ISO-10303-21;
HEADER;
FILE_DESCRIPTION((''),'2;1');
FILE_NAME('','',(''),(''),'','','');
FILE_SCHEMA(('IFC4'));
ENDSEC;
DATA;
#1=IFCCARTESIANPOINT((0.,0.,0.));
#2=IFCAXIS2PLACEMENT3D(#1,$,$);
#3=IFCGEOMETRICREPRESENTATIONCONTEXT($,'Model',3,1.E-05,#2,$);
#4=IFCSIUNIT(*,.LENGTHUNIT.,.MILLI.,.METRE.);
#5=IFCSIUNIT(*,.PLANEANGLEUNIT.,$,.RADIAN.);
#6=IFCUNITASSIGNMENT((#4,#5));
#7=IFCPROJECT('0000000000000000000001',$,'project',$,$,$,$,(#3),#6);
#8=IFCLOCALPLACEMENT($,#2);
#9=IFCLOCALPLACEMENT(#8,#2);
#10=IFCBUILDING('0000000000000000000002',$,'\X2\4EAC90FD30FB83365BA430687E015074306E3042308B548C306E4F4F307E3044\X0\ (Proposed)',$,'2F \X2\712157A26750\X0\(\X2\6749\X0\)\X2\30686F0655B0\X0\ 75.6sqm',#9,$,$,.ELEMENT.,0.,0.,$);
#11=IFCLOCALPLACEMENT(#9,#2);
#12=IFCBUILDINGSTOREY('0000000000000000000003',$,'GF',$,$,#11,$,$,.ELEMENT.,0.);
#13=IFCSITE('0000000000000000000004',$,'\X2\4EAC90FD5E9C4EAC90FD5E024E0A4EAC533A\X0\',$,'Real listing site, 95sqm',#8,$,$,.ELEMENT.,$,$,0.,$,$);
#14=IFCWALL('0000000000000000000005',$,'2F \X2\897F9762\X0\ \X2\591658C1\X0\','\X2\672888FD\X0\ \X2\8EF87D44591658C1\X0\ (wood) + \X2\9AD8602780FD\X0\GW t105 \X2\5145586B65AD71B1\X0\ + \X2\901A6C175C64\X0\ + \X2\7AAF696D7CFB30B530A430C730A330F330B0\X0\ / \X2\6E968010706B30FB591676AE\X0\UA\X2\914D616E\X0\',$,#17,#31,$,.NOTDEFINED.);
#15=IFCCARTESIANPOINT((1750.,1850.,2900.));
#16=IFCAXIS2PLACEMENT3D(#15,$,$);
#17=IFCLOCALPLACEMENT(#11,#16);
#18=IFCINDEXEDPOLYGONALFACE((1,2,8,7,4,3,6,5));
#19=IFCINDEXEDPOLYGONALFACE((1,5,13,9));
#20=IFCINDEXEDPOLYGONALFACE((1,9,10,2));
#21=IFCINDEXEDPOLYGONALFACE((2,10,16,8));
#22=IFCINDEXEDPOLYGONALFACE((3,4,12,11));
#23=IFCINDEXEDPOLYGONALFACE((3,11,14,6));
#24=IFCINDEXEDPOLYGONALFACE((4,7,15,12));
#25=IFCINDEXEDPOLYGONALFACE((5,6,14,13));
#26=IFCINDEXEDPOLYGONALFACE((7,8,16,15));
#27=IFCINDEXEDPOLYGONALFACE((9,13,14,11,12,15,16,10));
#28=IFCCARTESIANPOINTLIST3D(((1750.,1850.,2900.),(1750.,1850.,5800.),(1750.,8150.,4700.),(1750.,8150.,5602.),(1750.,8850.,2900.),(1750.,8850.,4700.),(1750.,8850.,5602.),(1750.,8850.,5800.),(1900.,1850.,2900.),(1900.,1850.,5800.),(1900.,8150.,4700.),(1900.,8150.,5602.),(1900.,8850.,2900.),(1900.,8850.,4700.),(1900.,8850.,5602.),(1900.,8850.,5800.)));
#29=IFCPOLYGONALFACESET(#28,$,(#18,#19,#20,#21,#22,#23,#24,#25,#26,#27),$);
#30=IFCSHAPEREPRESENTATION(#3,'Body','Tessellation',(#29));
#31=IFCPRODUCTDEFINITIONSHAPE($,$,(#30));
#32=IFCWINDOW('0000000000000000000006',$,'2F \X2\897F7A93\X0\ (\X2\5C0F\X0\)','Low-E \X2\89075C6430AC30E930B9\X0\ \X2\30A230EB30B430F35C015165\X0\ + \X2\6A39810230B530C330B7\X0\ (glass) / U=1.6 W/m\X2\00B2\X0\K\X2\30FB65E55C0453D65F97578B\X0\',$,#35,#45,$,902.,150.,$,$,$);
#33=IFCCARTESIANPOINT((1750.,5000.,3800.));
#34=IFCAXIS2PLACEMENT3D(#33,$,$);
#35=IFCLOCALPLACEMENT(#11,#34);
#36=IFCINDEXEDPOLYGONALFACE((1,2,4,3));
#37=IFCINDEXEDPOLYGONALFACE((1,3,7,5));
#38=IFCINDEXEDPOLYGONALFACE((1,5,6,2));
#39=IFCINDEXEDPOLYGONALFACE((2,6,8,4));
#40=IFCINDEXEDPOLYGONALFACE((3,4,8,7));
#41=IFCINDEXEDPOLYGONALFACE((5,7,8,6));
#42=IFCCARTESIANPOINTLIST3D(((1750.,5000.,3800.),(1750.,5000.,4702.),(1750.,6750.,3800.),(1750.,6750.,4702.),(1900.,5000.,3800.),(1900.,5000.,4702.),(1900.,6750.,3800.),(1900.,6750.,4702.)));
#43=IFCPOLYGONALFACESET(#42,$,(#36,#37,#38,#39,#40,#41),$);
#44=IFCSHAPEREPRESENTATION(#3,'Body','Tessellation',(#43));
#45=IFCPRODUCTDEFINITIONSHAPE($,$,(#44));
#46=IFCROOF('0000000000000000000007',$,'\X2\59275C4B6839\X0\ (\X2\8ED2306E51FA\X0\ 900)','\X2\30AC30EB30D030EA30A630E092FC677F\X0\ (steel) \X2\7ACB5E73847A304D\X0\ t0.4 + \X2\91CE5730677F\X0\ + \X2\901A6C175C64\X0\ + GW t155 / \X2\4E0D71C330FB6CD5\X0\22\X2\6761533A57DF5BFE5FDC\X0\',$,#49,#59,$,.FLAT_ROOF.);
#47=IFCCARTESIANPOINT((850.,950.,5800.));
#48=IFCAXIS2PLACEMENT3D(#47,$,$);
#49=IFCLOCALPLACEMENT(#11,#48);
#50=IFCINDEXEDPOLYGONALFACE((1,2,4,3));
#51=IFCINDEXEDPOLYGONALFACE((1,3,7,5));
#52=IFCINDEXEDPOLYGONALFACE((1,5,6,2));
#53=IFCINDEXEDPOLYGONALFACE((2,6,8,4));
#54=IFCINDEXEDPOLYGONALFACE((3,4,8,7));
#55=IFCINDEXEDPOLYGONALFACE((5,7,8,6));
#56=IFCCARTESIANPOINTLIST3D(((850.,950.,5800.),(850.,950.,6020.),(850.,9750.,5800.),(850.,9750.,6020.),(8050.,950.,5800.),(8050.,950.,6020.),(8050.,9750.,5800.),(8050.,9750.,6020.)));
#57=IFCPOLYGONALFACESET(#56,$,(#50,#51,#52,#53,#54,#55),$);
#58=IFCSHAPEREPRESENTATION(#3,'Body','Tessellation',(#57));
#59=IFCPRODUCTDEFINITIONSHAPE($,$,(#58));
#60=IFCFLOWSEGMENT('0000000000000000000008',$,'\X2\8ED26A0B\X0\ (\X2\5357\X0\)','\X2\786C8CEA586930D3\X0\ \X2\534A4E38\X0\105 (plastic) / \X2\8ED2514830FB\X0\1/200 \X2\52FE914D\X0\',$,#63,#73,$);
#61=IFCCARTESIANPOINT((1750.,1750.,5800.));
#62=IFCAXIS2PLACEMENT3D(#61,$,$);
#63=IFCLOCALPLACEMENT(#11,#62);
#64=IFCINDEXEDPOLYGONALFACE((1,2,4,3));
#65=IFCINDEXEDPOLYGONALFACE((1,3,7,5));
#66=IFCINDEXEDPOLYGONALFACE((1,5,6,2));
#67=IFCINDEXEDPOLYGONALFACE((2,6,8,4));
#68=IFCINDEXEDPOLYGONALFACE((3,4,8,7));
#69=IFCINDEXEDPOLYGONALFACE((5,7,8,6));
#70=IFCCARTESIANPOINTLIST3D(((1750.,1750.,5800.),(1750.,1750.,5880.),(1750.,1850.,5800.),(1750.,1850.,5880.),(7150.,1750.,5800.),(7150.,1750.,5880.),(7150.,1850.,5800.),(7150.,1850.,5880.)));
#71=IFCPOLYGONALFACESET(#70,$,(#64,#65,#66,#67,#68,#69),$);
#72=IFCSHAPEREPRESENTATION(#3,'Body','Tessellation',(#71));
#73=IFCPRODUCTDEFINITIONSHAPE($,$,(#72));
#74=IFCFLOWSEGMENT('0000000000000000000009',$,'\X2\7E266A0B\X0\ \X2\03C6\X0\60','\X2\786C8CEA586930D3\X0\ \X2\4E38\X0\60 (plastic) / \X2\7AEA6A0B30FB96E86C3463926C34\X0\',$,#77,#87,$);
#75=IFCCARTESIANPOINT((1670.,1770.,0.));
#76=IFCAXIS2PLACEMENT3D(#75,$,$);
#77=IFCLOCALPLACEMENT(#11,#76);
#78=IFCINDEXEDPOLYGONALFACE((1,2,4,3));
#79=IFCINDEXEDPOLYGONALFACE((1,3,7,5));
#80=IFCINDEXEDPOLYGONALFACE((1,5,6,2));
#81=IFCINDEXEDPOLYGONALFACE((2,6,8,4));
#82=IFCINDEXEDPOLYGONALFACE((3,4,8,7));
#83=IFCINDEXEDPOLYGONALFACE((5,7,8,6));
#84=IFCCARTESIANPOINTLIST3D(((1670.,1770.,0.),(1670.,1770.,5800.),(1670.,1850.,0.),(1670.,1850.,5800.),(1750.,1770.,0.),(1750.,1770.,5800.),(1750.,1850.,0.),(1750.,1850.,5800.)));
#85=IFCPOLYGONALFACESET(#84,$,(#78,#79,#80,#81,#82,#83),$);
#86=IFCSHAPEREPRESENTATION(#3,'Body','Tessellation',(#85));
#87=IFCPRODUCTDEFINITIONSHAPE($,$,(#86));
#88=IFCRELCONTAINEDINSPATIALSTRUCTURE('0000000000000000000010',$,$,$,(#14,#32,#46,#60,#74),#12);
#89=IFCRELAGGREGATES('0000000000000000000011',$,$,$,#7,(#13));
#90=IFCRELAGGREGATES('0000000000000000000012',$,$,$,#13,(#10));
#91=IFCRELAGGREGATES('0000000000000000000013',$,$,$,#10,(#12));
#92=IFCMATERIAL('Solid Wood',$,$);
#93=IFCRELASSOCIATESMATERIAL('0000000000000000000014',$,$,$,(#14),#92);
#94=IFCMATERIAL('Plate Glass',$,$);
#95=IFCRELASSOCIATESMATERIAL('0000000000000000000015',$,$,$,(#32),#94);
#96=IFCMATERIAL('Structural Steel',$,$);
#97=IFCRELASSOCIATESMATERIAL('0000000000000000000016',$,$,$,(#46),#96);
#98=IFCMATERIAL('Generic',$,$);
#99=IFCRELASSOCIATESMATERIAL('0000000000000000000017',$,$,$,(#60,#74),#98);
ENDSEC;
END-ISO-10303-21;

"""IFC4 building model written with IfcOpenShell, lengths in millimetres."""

from ifc_helpers import new_model, si_unit, frame, frame_2d, origin, place, context, project, spatial, rectangle, extrude, material, element, fill, save


model = new_model("IFC4")

# Units and contexts
model_context = context("Model", 3, precision=1e-05, world=origin())
ifc_project = project(units=[si_unit("LENGTHUNIT", "METRE", prefix="MILLI"), si_unit("PLANEANGLEUNIT", "RADIAN")], contexts=[model_context])

# Site, building, storey
site_placement = place(None, origin())
site = spatial("IfcSite", under=ifc_project, at=site_placement, Name="京都府京都市上京区", ObjectType="Real listing site, 95sqm", CompositionType="ELEMENT", RefElevation=0.0)
building_placement = place(site_placement, origin())
building = spatial("IfcBuilding", under=site, at=building_placement, Name="京都・茶室と縁側のある和の住まい (Proposed)", ObjectType="2F 無垢材(杉)と漆喰 75.6sqm", CompositionType="ELEMENT", ElevationOfRefHeight=0.0, ElevationOfTerrain=0.0)
storey_placement = place(building_placement, origin())
storey = spatial("IfcBuildingStorey", under=building, at=storey_placement, Name="GF", CompositionType="ELEMENT", Elevation=0.0)

# Shared definitions
ifc_material_1 = material(Name="Solid Wood")

# Shared definitions
ifc_material_2 = material(Name="Plate Glass")

# Wall, opening, window
wall_1_placement = place(storey_placement, frame((1750.0, 1850.0, 2900.0)))
wall_1 = element("IfcWall", 1, at=wall_1_placement, inside=storey, material=ifc_material_1, Name="2F 西面 外壁", Description="木製 軸組外壁 (wood) + 高性能GW t105 充填断熱 + 通気層 + 窯業系サイディング / 準耐火・外皮UA配慮", PredefinedType="NOTDEFINED", context=model_context, shape_type="SweptSolid", body=[
    extrude(rectangle(XDim=150.0, YDim=7000.0, at=frame_2d((75.0, 3500.0))), frame((1750.0, 1850.0, 2900.0)), (0.0, 0.0, 1.0), 2900.0),
])
opening_1_placement = place(storey_placement, frame((1750.0, 5000.0, 3800.0)))
opening_1 = element("IfcOpeningElement", 2, at=opening_1_placement, cuts=wall_1, PredefinedType="NOTDEFINED", context=model_context, shape_type="SweptSolid", body=[
    extrude(rectangle(XDim=150.0, YDim=1750.0, at=frame_2d((75.0, 875.0))), frame((1750.0, 5000.0, 3800.0)), (0.0, 0.0, 1.0), 902.0),
])
window_1_placement = place(storey_placement, frame((1750.0, 5000.0, 3800.0)))
window_1 = element("IfcWindow", 3, at=window_1_placement, inside=storey, material=ifc_material_2, Name="2F 西窓 (小)", Description="Low-E 複層ガラス アルゴン封入 + 樹脂サッシ (glass) / U=1.6 W/m²K・日射取得型", OverallHeight=902.0, OverallWidth=150.0, context=model_context, shape_type="SweptSolid", body=[
    extrude(rectangle(XDim=150.0, YDim=1750.0, at=frame_2d((75.0, 875.0))), frame((1750.0, 5000.0, 3800.0)), (0.0, 0.0, 1.0), 902.0),
])
fill(opening_1, window_1)

# Roof
ifc_material_3 = material(Name="Structural Steel")
roof_placement = place(storey_placement, frame((850.0, 950.0, 5800.0)))
element("IfcRoof", 4, at=roof_placement, inside=storey, material=ifc_material_3, Name="大屋根 (軒の出 900)", Description="ガルバリウム鋼板 (steel) 立平葺き t0.4 + 野地板 + 通気層 + GW t155 / 不燃・法22条区域対応", PredefinedType="FLAT_ROOF", context=model_context, shape_type="SweptSolid", body=[
    extrude(rectangle(XDim=7200.0, YDim=8800.0, at=frame_2d((3600.0, 4400.0))), frame((850.0, 950.0, 5800.0)), (0.0, 0.0, 1.0), 220.0),
])

# Flow segments
ifc_material_4 = material(Name="Generic")
flow_segment_1_placement = place(storey_placement, frame((1750.0, 1750.0, 5800.0)))
element("IfcFlowSegment", 5, at=flow_segment_1_placement, inside=storey, material=ifc_material_4, Name="軒樋 (南)", Description="硬質塩ビ 半丸105 (plastic) / 軒先・1/200 勾配", context=model_context, shape_type="SweptSolid", body=[
    extrude(rectangle(XDim=5400.0, YDim=100.0, at=frame_2d((2700.0, 50.0))), frame((1750.0, 1750.0, 5800.0)), (0.0, 0.0, 1.0), 80.0),
])
flow_segment_2_placement = place(storey_placement, frame((1670.0, 1770.0, 0.0)))
element("IfcFlowSegment", 6, at=flow_segment_2_placement, inside=storey, material=ifc_material_4, Name="縦樋 φ60", Description="硬質塩ビ 丸60 (plastic) / 竪樋・雨水排水", context=model_context, shape_type="SweptSolid", body=[
    extrude(rectangle(XDim=80.0, YDim=80.0, at=frame_2d((40.0, 40.0))), frame((1670.0, 1770.0, 0.0)), (0.0, 0.0, 1.0), 5800.0),
])

save(model, "model.ifc")
